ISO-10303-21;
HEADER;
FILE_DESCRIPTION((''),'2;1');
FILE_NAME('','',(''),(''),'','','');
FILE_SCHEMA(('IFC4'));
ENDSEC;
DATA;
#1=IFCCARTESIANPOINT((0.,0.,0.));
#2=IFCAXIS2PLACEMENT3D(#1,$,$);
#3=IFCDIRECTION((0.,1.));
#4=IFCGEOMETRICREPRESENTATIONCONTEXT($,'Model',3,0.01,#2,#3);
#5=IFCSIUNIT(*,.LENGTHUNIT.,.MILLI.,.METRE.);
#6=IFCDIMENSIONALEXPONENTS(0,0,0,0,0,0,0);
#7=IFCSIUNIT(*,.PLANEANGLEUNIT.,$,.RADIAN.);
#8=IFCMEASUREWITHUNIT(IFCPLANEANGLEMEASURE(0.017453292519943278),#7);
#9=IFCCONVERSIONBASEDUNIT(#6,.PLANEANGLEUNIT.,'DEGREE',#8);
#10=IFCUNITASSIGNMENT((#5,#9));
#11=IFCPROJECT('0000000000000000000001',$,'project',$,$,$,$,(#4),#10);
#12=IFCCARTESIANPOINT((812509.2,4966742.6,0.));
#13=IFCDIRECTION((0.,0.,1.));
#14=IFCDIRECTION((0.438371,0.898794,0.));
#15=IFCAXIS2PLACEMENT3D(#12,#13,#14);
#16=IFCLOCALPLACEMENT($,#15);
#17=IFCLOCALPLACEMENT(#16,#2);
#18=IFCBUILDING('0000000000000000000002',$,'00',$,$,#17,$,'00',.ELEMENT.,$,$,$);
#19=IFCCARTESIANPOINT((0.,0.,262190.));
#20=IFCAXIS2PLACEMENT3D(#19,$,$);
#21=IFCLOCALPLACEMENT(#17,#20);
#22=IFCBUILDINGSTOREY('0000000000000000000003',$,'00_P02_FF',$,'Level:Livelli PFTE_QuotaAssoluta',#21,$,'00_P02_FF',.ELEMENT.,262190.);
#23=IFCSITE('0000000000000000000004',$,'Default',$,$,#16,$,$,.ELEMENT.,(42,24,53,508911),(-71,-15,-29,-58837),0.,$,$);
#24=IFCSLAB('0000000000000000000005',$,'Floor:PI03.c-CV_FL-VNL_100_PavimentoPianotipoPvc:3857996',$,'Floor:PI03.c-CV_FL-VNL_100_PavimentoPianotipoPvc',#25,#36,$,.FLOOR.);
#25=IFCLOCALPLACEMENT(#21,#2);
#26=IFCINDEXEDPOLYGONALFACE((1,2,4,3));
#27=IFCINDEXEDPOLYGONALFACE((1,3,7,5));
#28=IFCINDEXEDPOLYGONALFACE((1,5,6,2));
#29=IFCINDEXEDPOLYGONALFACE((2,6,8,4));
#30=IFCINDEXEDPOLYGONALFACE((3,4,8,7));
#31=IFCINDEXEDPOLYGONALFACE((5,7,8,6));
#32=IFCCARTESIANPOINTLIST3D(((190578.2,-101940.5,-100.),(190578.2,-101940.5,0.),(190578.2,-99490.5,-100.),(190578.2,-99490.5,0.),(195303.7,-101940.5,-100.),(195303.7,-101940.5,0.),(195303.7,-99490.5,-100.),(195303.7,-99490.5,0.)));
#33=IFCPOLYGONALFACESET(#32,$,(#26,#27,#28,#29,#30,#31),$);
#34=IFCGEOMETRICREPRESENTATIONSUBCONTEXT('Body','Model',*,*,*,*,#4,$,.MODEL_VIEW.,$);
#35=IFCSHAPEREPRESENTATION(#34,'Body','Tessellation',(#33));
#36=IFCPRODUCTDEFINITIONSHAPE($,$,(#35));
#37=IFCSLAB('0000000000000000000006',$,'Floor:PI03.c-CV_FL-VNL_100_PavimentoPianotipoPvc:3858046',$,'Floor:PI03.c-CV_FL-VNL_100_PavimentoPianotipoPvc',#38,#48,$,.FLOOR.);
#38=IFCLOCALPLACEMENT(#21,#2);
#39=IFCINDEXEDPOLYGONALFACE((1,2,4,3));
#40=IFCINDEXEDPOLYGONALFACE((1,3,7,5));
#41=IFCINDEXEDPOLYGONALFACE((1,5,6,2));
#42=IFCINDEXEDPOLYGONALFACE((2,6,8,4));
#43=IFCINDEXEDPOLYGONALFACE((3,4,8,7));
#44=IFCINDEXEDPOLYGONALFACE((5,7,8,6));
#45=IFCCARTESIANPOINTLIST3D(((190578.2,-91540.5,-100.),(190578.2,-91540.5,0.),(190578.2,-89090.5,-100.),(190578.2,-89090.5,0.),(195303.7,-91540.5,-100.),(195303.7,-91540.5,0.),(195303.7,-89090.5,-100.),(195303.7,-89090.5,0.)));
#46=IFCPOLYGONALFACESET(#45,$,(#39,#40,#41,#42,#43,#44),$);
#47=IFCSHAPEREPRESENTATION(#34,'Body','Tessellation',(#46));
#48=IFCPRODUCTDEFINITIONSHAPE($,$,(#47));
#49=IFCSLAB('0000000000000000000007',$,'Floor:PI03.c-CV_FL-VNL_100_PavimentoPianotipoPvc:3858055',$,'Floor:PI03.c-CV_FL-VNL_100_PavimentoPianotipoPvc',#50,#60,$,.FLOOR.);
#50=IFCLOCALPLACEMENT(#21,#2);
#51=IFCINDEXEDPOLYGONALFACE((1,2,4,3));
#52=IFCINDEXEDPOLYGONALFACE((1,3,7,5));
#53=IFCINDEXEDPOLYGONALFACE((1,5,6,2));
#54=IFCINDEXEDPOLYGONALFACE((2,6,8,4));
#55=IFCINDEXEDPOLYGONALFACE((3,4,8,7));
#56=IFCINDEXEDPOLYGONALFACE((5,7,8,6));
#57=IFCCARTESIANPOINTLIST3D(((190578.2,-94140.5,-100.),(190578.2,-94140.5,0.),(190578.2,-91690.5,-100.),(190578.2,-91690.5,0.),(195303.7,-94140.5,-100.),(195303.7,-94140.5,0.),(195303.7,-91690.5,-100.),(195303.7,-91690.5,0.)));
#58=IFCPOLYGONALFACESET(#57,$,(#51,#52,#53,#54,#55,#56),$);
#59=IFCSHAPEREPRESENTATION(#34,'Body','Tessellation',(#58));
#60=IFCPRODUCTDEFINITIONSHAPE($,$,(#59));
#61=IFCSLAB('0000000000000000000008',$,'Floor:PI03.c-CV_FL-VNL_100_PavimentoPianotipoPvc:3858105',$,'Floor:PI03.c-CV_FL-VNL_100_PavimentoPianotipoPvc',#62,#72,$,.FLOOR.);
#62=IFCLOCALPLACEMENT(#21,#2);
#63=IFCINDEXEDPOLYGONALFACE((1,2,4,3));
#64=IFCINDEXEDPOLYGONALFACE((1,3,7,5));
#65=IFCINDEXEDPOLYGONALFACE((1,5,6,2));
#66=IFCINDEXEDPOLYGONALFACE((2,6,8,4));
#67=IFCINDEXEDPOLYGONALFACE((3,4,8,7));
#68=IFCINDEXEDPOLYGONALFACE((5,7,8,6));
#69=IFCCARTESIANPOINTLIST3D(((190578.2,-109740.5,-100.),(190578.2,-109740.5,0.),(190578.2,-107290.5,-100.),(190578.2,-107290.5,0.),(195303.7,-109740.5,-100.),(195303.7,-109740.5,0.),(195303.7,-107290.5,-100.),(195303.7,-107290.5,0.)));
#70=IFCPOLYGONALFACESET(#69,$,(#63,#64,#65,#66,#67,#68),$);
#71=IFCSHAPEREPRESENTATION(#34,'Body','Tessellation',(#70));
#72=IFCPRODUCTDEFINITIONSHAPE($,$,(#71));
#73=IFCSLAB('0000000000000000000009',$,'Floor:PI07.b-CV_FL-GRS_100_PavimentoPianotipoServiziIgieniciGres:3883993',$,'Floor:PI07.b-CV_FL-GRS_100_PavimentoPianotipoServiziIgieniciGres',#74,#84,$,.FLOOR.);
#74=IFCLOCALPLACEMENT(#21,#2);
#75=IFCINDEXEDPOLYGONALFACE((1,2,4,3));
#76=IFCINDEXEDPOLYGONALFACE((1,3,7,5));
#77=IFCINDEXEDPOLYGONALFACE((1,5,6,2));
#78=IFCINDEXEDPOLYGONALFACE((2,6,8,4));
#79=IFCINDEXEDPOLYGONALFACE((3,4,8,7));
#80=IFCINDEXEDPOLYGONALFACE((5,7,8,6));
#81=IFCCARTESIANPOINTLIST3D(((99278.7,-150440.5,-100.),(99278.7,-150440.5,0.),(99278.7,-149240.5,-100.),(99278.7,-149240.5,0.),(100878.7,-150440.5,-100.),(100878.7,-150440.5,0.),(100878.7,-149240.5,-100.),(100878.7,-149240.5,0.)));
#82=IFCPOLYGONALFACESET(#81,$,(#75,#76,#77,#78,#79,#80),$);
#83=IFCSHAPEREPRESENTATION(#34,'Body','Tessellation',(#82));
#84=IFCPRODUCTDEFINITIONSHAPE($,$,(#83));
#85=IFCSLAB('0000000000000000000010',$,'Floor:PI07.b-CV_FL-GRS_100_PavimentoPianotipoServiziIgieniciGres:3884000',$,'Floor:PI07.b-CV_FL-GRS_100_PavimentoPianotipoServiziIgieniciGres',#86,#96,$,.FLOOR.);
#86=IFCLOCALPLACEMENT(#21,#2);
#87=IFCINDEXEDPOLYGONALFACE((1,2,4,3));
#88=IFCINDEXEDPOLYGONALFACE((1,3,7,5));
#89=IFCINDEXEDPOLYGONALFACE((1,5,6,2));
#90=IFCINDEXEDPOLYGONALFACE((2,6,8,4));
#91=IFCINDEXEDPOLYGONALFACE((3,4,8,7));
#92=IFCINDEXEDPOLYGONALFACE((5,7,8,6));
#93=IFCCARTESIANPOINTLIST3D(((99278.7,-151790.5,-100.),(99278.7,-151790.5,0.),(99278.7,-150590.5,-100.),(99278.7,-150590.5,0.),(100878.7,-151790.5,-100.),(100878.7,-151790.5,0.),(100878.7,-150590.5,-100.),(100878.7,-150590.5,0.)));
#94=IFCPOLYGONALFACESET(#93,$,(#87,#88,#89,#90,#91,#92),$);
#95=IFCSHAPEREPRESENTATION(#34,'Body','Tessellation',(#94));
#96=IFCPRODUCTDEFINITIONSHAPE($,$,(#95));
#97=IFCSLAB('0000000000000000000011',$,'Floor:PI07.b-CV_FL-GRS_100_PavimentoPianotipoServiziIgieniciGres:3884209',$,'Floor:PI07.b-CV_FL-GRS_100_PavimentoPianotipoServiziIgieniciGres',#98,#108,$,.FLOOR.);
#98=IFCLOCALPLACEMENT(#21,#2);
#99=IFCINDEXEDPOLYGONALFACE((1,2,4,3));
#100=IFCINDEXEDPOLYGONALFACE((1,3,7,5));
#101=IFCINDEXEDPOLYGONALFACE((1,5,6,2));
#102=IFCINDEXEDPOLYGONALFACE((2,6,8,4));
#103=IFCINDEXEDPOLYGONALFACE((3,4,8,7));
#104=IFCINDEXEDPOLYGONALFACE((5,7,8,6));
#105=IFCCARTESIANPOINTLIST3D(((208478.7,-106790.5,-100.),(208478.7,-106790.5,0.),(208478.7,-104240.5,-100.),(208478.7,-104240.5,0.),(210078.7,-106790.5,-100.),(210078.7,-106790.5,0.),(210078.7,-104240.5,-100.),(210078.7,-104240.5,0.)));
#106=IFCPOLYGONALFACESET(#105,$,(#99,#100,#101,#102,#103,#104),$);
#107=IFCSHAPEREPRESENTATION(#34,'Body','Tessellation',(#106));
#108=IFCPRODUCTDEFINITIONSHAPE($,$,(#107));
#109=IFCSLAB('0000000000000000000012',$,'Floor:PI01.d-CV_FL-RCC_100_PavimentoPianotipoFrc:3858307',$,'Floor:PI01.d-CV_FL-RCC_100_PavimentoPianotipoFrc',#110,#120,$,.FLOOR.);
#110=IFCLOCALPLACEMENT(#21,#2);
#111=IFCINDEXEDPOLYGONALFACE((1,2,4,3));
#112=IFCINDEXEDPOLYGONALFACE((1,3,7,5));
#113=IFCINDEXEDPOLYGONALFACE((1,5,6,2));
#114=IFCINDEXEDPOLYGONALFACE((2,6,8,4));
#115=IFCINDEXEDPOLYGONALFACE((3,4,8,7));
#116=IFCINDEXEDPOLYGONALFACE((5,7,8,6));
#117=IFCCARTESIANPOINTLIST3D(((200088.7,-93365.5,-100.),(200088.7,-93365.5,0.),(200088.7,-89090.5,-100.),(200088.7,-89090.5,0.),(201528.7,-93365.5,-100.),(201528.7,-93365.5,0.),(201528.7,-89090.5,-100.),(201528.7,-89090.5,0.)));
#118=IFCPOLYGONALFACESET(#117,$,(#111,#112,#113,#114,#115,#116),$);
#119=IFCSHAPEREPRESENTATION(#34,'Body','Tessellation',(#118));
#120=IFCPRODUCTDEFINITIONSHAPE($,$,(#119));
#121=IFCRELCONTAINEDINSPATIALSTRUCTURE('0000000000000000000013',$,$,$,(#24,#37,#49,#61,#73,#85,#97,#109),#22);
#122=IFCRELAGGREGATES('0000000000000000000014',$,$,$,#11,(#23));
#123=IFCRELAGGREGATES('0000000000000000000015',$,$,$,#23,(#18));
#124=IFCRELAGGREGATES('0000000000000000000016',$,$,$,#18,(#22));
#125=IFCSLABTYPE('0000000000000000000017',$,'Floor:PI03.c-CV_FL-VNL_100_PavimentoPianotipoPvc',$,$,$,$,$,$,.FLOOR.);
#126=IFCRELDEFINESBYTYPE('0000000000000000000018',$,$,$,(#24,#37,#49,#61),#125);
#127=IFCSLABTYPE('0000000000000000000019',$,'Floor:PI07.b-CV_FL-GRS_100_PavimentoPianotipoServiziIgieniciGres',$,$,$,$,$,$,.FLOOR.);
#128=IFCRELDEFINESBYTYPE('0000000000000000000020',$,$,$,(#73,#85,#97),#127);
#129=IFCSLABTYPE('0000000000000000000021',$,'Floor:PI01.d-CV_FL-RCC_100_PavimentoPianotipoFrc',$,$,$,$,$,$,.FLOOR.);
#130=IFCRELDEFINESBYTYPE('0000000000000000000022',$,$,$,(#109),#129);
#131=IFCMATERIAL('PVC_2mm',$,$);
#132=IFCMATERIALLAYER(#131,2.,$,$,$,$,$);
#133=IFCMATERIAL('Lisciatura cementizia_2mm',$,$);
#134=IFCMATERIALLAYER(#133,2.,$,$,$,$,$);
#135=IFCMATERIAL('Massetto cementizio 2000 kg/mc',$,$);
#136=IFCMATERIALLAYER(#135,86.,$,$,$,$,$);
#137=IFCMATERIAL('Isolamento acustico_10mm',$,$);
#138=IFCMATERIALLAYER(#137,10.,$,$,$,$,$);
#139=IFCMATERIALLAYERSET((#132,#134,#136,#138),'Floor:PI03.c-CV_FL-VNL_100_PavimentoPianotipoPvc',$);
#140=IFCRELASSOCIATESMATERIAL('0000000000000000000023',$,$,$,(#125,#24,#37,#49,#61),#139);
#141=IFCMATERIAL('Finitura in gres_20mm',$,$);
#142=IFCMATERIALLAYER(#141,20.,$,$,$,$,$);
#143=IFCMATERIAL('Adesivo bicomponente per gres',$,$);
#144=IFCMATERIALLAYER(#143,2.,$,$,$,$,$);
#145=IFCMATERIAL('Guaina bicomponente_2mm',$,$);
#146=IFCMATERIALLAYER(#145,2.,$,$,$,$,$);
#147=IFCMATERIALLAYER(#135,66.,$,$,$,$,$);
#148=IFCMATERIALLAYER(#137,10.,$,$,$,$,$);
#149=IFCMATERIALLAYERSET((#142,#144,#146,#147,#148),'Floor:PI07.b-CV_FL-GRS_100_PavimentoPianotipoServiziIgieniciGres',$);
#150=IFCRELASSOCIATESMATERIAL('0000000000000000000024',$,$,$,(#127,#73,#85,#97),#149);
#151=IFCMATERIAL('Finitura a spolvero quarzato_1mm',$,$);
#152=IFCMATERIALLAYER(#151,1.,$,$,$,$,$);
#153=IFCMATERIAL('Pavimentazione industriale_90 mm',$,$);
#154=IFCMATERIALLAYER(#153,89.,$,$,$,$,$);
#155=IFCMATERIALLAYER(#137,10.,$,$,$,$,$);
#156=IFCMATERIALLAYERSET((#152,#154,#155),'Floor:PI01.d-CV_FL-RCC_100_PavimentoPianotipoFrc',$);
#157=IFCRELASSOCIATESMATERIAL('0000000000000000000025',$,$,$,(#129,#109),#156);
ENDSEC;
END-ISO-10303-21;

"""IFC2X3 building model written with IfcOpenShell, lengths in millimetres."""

from ifc_helpers import new_model, entity, si_unit, converted_unit, direction, frame, frame_2d, origin, origin_2d_with_axis, place, context, subcontext, project, spatial, rectangle, extrude, material, layer, layer_set, layer_usage, type_object, element, save


model = new_model("IFC2X3")

# Units and contexts
model_context = context("Model", 3, precision=0.01, world=origin(), true_north=direction((0.0, 1.0)))
body_context = subcontext(model_context, "Body", "Model", "MODEL_VIEW")
ifc_project = project(units=[si_unit("LENGTHUNIT", "METRE", prefix="MILLI"), converted_unit("PLANEANGLEUNIT", "DEGREE", entity("IfcPlaneAngleMeasure", 0.017453292519943278), si_unit("PLANEANGLEUNIT", "RADIAN"), dimensions=[0, 0, 0, 0, 0, 0, 0])], contexts=[model_context])

# Site, building, storey
site_placement = place(None, frame((812509.2, 4966742.6, 0.0), z_axis=(0.0, 0.0, 1.0), x_axis=(0.438371, 0.898794, 0.0)))
site = spatial("IfcSite", under=ifc_project, at=site_placement, Name="Default", CompositionType="ELEMENT", RefLatitude=(42, 24, 53, 508911), RefLongitude=(-71, -15, -29, -58837), RefElevation=0.0)
building_placement = place(site_placement, origin())
building = spatial("IfcBuilding", under=site, at=building_placement, Name="00", LongName="00", CompositionType="ELEMENT")
storey_placement = place(building_placement, frame((0.0, 0.0, 262190.0)))
storey = spatial("IfcBuildingStorey", under=building, at=storey_placement, Name="00_P02_FF", ObjectType="Level:Livelli PFTE_QuotaAssoluta", LongName="00_P02_FF", CompositionType="ELEMENT", Elevation=262190.0)

# Slabs
ifc_material_1 = material(Name="PVC_2mm")
ifc_layer_1 = layer(ifc_material_1, 2.0)
ifc_material_2 = material(Name="Lisciatura cementizia_2mm")
ifc_layer_2 = layer(ifc_material_2, 2.0)
ifc_material_3 = material(Name="Massetto cementizio 2000 kg/mc")
ifc_layer_3 = layer(ifc_material_3, 86.0)
ifc_material_4 = material(Name="Isolamento acustico_10mm")
ifc_layer_4 = layer(ifc_material_4, 10.0)
ifc_layer_set_1 = layer_set([ifc_layer_1, ifc_layer_2, ifc_layer_3, ifc_layer_4], Name="Floor:PI03.c-CV_FL-VNL_100_PavimentoPianotipoPvc")
ifc_layer_usage_1 = layer_usage(ifc_layer_set_1, "AXIS3", "POSITIVE", 0.0)
slab_type_1 = type_object("IfcSlabType", Name="Floor:PI03.c-CV_FL-VNL_100_PavimentoPianotipoPvc", PredefinedType="FLOOR", material=ifc_layer_set_1)
slab_1_placement = place(storey_placement, origin())
element("IfcSlab", 1, at=slab_1_placement, inside=storey, type_object=slab_type_1, material=ifc_layer_usage_1, Name="Floor:PI03.c-CV_FL-VNL_100_PavimentoPianotipoPvc:3857996", ObjectType="Floor:PI03.c-CV_FL-VNL_100_PavimentoPianotipoPvc", PredefinedType="FLOOR", context=body_context, shape_type="SweptSolid", body=[
    extrude(rectangle(XDim=2450.0, YDim=4725.5, at=frame_2d((0.0, 0.0), x_axis=(1.0, 0.0))), frame((192940.9, -100715.5, 0.0), z_axis=(0.0, 0.0, -1.0), x_axis=(0.0, 1.0, 0.0)), (0.0, 0.0, 1.0), 100.0),
])
ifc_layer_usage_2 = layer_usage(ifc_layer_set_1, "AXIS3", "POSITIVE", 0.0)
slab_2_placement = place(storey_placement, origin())
element("IfcSlab", 2, at=slab_2_placement, inside=storey, type_object=slab_type_1, material=ifc_layer_usage_2, Name="Floor:PI03.c-CV_FL-VNL_100_PavimentoPianotipoPvc:3858046", ObjectType="Floor:PI03.c-CV_FL-VNL_100_PavimentoPianotipoPvc", PredefinedType="FLOOR", context=body_context, shape_type="SweptSolid", body=[
    extrude(rectangle(XDim=2450.0, YDim=4725.5, at=frame_2d((0.0, 0.0), x_axis=(1.0, 0.0))), frame((192940.9, -90315.5, 0.0), z_axis=(0.0, 0.0, -1.0), x_axis=(0.0, 1.0, 0.0)), (0.0, 0.0, 1.0), 100.0),
])
ifc_layer_usage_3 = layer_usage(ifc_layer_set_1, "AXIS3", "POSITIVE", 0.0)
slab_3_placement = place(storey_placement, origin())
element("IfcSlab", 3, at=slab_3_placement, inside=storey, type_object=slab_type_1, material=ifc_layer_usage_3, Name="Floor:PI03.c-CV_FL-VNL_100_PavimentoPianotipoPvc:3858055", ObjectType="Floor:PI03.c-CV_FL-VNL_100_PavimentoPianotipoPvc", PredefinedType="FLOOR", context=body_context, shape_type="SweptSolid", body=[
    extrude(rectangle(XDim=2450.0, YDim=4725.5, at=frame_2d((0.0, 0.0), x_axis=(1.0, 0.0))), frame((192940.9, -92915.5, 0.0), z_axis=(0.0, 0.0, -1.0), x_axis=(0.0, 1.0, 0.0)), (0.0, 0.0, 1.0), 100.0),
])
ifc_layer_usage_4 = layer_usage(ifc_layer_set_1, "AXIS3", "POSITIVE", 0.0)
slab_4_placement = place(storey_placement, origin())
element("IfcSlab", 4, at=slab_4_placement, inside=storey, type_object=slab_type_1, material=ifc_layer_usage_4, Name="Floor:PI03.c-CV_FL-VNL_100_PavimentoPianotipoPvc:3858105", ObjectType="Floor:PI03.c-CV_FL-VNL_100_PavimentoPianotipoPvc", PredefinedType="FLOOR", context=body_context, shape_type="SweptSolid", body=[
    extrude(rectangle(XDim=2450.0, YDim=4725.5, at=frame_2d((0.0, 0.0), x_axis=(1.0, 0.0))), frame((192940.9, -108515.5, 0.0), z_axis=(0.0, 0.0, -1.0), x_axis=(0.0, 1.0, 0.0)), (0.0, 0.0, 1.0), 100.0),
])

# Slabs
ifc_material_5 = material(Name="Finitura in gres_20mm")
ifc_layer_5 = layer(ifc_material_5, 20.0)
ifc_material_6 = material(Name="Adesivo bicomponente per gres")
ifc_layer_6 = layer(ifc_material_6, 2.0)
ifc_material_7 = material(Name="Guaina bicomponente_2mm")
ifc_layer_7 = layer(ifc_material_7, 2.0)
ifc_layer_8 = layer(ifc_material_3, 66.0)
ifc_layer_9 = layer(ifc_material_4, 10.0)
ifc_layer_set_2 = layer_set([ifc_layer_5, ifc_layer_6, ifc_layer_7, ifc_layer_8, ifc_layer_9], Name="Floor:PI07.b-CV_FL-GRS_100_PavimentoPianotipoServiziIgieniciGres")
ifc_layer_usage_5 = layer_usage(ifc_layer_set_2, "AXIS3", "POSITIVE", 0.0)
slab_type_2 = type_object("IfcSlabType", Name="Floor:PI07.b-CV_FL-GRS_100_PavimentoPianotipoServiziIgieniciGres", PredefinedType="FLOOR", material=ifc_layer_set_2)
slab_5_placement = place(storey_placement, origin())
element("IfcSlab", 5, at=slab_5_placement, inside=storey, type_object=slab_type_2, material=ifc_layer_usage_5, Name="Floor:PI07.b-CV_FL-GRS_100_PavimentoPianotipoServiziIgieniciGres:3883993", ObjectType="Floor:PI07.b-CV_FL-GRS_100_PavimentoPianotipoServiziIgieniciGres", PredefinedType="FLOOR", context=body_context, shape_type="SweptSolid", body=[
    extrude(rectangle(XDim=1200.0, YDim=1600.0, at=frame_2d((0.0, 0.0), x_axis=(1.0, 0.0))), frame((100078.7, -149840.5, 0.0), z_axis=(0.0, 0.0, -1.0), x_axis=(0.0, 1.0, 0.0)), (0.0, 0.0, 1.0), 100.0),
])
ifc_layer_usage_6 = layer_usage(ifc_layer_set_2, "AXIS3", "POSITIVE", 0.0)
slab_6_placement = place(storey_placement, origin())
element("IfcSlab", 6, at=slab_6_placement, inside=storey, type_object=slab_type_2, material=ifc_layer_usage_6, Name="Floor:PI07.b-CV_FL-GRS_100_PavimentoPianotipoServiziIgieniciGres:3884000", ObjectType="Floor:PI07.b-CV_FL-GRS_100_PavimentoPianotipoServiziIgieniciGres", PredefinedType="FLOOR", context=body_context, shape_type="SweptSolid", body=[
    extrude(rectangle(XDim=1200.0, YDim=1600.0, at=origin_2d_with_axis()), frame((100078.7, -151190.5, 0.0), z_axis=(0.0, 0.0, -1.0), x_axis=(0.0, 1.0, 0.0)), (0.0, 0.0, 1.0), 100.0),
])
ifc_layer_usage_7 = layer_usage(ifc_layer_set_2, "AXIS3", "POSITIVE", 0.0)
slab_7_placement = place(storey_placement, origin())
element("IfcSlab", 7, at=slab_7_placement, inside=storey, type_object=slab_type_2, material=ifc_layer_usage_7, Name="Floor:PI07.b-CV_FL-GRS_100_PavimentoPianotipoServiziIgieniciGres:3884209", ObjectType="Floor:PI07.b-CV_FL-GRS_100_PavimentoPianotipoServiziIgieniciGres", PredefinedType="FLOOR", context=body_context, shape_type="SweptSolid", body=[
    extrude(rectangle(XDim=2550.0, YDim=1600.0, at=frame_2d((0.0, 0.0), x_axis=(1.0, 0.0))), frame((209278.7, -105515.5, 0.0), z_axis=(0.0, 0.0, -1.0), x_axis=(0.0, 1.0, 0.0)), (0.0, 0.0, 1.0), 100.0),
])
ifc_material_8 = material(Name="Finitura a spolvero quarzato_1mm")
ifc_layer_10 = layer(ifc_material_8, 1.0)
ifc_material_9 = material(Name="Pavimentazione industriale_90 mm")
ifc_layer_11 = layer(ifc_material_9, 89.0)
ifc_layer_12 = layer(ifc_material_4, 10.0)
ifc_layer_set_3 = layer_set([ifc_layer_10, ifc_layer_11, ifc_layer_12], Name="Floor:PI01.d-CV_FL-RCC_100_PavimentoPianotipoFrc")
slab_type_3 = type_object("IfcSlabType", Name="Floor:PI01.d-CV_FL-RCC_100_PavimentoPianotipoFrc", PredefinedType="FLOOR", material=ifc_layer_set_3)
ifc_layer_usage_8 = layer_usage(ifc_layer_set_3, "AXIS3", "POSITIVE", 0.0)
slab_8_placement = place(storey_placement, origin())
element("IfcSlab", 8, at=slab_8_placement, inside=storey, type_object=slab_type_3, material=ifc_layer_usage_8, Name="Floor:PI01.d-CV_FL-RCC_100_PavimentoPianotipoFrc:3858307", ObjectType="Floor:PI01.d-CV_FL-RCC_100_PavimentoPianotipoFrc", PredefinedType="FLOOR", context=body_context, shape_type="SweptSolid", body=[
    extrude(rectangle(XDim=4275.0, YDim=1440.0, at=frame_2d((0.0, 0.0), x_axis=(1.0, 0.0))), frame((200808.7, -91228.0, 0.0), z_axis=(0.0, 0.0, -1.0), x_axis=(0.0, 1.0, 0.0)), (0.0, 0.0, 1.0), 100.0),
])

save(model, "model.ifc")
